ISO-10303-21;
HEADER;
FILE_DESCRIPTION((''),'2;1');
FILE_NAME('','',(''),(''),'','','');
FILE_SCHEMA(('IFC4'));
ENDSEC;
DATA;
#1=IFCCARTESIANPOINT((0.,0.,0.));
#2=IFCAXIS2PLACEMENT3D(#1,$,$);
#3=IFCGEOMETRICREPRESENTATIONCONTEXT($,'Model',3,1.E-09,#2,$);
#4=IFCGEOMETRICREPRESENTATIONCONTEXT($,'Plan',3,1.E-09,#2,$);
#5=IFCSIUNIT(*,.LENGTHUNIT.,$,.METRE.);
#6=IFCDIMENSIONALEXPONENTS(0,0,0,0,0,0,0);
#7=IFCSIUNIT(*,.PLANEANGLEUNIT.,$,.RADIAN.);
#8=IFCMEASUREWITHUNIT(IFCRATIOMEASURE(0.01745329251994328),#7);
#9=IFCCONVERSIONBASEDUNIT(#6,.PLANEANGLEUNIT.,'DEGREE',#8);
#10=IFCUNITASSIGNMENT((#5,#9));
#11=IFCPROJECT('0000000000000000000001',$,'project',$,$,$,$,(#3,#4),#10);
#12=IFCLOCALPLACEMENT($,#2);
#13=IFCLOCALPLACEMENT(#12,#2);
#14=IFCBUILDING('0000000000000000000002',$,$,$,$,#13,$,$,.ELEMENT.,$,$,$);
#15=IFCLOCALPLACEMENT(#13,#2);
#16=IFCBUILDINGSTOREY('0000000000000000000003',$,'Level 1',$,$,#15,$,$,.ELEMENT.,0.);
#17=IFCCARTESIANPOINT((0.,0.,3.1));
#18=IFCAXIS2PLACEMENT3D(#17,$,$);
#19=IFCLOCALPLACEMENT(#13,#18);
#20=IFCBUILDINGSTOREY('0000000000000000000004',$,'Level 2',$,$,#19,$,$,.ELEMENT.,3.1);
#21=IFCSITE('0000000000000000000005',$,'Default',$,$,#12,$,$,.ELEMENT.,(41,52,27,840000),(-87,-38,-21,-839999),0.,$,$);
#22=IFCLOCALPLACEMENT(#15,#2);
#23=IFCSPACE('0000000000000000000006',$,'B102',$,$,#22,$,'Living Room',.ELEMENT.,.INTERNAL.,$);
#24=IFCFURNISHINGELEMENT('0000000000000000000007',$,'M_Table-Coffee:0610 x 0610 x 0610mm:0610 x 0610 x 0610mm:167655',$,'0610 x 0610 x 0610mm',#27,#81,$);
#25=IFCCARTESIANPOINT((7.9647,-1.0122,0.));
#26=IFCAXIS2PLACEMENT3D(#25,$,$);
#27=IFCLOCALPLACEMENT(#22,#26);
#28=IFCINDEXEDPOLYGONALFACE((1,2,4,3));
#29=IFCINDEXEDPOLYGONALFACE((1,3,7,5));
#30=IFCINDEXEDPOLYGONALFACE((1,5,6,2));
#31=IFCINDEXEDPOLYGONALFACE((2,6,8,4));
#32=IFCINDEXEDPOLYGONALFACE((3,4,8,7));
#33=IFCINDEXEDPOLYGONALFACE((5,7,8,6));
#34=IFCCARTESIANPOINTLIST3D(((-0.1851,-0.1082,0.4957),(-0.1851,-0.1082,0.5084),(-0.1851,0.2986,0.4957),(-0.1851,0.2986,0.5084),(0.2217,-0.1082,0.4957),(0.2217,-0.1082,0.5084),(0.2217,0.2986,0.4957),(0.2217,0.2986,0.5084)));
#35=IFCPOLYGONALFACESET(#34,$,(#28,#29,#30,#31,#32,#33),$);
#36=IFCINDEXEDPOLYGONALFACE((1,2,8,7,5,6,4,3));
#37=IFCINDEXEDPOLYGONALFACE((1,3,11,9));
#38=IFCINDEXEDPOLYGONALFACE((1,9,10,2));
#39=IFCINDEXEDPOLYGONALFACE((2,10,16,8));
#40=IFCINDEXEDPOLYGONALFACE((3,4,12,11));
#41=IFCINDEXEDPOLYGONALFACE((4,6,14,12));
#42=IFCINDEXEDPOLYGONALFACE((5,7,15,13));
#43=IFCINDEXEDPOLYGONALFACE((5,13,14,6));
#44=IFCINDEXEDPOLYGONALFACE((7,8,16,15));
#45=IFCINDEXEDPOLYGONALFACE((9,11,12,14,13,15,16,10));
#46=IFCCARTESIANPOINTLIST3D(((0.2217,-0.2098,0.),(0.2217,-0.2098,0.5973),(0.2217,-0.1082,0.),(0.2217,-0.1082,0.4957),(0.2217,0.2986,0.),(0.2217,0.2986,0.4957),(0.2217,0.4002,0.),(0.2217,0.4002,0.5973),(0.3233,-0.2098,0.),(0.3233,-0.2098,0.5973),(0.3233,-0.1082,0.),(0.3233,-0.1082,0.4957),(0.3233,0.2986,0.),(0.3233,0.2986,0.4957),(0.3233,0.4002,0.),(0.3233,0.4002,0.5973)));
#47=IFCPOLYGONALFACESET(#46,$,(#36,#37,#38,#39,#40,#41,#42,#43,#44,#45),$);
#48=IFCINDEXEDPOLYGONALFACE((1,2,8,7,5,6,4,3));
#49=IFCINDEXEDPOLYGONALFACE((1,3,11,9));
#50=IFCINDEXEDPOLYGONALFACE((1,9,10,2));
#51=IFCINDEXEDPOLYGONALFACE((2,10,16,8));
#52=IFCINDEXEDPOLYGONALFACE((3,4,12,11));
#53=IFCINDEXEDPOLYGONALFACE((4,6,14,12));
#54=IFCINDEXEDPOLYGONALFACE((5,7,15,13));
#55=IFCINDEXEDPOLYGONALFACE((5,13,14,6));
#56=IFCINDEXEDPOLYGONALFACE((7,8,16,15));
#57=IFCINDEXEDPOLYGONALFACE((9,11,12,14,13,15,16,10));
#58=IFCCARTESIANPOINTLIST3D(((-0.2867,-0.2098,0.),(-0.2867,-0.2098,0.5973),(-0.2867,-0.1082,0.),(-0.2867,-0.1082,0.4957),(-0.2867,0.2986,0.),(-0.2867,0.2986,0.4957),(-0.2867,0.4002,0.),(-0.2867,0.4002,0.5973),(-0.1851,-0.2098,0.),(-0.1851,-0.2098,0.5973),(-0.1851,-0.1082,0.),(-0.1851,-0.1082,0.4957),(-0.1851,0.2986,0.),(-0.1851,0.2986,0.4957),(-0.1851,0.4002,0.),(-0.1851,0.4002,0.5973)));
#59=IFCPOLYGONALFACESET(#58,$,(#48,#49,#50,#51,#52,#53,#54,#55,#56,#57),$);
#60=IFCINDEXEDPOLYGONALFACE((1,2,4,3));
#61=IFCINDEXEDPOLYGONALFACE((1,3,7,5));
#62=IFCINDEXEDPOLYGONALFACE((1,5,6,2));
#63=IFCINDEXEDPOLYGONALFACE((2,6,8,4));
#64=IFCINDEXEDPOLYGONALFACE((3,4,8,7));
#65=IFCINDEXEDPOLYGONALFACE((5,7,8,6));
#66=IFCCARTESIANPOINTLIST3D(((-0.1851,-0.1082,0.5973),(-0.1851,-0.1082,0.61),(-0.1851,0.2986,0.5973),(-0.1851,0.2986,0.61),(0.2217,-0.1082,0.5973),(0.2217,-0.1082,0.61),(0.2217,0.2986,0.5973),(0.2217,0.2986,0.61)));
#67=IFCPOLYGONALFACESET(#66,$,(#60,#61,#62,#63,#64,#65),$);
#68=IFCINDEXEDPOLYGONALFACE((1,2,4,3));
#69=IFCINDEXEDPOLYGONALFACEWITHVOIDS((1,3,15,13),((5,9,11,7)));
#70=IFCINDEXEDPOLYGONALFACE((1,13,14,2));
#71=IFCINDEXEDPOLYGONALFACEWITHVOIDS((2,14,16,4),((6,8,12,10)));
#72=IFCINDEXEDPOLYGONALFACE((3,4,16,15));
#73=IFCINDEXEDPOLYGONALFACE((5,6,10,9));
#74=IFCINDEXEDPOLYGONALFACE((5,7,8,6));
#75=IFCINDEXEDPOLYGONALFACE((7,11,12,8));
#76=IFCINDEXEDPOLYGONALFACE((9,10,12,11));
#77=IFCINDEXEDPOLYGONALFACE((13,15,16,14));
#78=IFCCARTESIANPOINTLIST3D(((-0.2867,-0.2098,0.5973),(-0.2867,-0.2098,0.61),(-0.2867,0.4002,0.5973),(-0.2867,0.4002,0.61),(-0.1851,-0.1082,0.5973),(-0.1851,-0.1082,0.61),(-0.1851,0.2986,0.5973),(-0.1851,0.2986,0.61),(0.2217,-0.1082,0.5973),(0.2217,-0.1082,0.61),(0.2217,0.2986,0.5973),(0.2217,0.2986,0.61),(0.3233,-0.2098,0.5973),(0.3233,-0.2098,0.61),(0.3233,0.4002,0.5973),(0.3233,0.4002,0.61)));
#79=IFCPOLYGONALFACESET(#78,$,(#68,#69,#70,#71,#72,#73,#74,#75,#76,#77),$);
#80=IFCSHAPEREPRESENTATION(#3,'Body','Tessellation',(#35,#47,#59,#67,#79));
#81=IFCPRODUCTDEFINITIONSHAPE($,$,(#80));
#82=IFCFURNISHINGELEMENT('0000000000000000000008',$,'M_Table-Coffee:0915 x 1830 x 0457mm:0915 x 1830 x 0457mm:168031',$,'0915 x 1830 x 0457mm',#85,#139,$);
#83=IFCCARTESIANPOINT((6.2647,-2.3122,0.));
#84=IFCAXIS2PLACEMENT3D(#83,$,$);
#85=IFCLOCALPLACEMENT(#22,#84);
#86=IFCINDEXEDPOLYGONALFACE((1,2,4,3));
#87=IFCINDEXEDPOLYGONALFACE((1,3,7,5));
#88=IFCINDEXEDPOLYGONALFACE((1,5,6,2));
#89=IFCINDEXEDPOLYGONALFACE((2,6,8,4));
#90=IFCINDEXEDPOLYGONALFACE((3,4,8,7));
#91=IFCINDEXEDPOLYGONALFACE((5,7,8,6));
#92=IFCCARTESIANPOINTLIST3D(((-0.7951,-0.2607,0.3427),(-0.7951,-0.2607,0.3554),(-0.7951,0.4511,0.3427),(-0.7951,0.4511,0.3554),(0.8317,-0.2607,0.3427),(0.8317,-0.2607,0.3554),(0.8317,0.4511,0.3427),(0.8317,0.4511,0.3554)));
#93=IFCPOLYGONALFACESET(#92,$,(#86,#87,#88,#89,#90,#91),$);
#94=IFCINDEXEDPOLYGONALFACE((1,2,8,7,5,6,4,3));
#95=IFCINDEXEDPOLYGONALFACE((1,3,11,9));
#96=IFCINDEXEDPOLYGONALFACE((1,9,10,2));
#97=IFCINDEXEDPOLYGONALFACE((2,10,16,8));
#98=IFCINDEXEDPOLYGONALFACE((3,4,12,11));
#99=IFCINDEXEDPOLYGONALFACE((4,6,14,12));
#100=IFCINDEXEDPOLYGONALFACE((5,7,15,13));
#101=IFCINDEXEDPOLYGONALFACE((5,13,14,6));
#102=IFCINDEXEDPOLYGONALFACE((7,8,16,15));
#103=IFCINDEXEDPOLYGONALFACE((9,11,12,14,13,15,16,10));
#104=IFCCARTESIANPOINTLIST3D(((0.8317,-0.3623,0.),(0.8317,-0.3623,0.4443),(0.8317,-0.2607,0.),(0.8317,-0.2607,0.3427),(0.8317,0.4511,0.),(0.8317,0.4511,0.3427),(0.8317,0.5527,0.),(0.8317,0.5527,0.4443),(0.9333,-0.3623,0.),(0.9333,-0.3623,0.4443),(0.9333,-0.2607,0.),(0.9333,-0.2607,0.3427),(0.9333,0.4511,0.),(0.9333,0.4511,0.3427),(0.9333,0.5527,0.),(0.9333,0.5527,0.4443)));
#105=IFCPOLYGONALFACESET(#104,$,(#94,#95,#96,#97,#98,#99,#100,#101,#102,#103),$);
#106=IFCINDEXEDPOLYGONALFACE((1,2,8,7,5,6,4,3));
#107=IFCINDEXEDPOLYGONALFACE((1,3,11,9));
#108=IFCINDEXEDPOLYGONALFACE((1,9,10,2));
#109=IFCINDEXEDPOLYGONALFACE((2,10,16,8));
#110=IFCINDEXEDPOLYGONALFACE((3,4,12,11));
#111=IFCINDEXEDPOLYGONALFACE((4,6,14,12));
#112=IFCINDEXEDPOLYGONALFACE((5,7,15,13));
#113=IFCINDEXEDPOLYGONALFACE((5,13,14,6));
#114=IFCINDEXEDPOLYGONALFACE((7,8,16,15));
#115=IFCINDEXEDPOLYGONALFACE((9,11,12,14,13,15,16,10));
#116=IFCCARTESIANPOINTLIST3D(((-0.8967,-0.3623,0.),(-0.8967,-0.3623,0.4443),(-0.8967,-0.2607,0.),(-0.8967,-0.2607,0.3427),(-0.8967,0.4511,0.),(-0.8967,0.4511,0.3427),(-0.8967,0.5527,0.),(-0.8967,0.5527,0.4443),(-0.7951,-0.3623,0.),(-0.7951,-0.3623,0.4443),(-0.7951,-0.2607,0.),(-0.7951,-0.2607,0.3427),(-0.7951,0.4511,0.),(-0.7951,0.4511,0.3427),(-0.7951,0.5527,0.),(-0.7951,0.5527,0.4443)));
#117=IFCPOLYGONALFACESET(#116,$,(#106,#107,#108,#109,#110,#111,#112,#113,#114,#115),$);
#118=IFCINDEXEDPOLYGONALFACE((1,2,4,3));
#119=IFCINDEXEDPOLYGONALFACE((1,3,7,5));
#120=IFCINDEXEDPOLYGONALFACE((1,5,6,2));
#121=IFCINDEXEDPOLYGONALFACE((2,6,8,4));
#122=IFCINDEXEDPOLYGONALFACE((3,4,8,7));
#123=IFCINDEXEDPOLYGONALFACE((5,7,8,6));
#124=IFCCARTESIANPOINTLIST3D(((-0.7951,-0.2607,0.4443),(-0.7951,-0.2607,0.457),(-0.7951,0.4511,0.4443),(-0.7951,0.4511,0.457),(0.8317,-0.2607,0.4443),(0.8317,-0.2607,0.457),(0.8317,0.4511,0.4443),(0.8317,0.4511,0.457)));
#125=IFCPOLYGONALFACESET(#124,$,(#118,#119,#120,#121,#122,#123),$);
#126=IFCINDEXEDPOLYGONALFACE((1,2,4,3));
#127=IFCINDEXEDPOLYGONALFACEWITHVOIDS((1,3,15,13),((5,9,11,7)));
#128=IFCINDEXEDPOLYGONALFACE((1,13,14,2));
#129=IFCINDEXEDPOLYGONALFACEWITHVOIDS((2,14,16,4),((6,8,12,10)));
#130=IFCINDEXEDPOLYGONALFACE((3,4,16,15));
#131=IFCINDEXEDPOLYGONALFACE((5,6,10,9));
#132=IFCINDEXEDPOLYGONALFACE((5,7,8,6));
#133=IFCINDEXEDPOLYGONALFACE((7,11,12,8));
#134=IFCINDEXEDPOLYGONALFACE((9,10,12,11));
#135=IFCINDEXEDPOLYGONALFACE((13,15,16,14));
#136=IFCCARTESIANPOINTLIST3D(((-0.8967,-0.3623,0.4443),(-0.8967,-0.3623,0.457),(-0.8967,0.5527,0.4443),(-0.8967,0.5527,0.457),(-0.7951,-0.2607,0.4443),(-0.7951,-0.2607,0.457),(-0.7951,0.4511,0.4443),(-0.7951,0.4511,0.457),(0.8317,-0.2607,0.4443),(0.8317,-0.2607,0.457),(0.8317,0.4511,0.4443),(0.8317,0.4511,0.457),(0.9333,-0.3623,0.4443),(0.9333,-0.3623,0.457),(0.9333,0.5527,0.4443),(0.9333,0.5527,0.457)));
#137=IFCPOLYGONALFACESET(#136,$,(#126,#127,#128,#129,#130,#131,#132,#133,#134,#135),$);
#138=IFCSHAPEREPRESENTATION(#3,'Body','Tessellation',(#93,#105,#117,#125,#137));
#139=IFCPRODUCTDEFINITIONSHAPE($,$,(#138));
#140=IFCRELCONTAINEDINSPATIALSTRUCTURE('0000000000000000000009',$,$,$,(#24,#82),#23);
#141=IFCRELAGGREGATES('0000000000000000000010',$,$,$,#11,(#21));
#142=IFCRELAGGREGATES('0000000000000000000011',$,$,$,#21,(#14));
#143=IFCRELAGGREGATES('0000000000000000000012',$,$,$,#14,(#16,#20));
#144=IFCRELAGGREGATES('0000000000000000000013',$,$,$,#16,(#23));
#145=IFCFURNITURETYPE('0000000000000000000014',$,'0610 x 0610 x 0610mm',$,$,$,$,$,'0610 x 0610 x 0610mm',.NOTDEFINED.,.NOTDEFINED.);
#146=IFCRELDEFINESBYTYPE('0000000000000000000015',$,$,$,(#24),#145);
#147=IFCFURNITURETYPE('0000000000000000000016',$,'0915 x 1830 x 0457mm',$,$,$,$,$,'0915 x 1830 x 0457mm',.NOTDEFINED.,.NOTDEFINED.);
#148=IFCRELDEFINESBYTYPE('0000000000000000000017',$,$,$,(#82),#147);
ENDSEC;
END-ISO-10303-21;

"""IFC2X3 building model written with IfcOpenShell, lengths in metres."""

from ifc_helpers import new_model, entity, si_unit, converted_unit, frame, origin, origin_2d_with_axis, place, context, project, spatial, polyline, rectangle, outline, extrude, source, transform, mapped, type_object, type_shapes, element, save


model = new_model("IFC2X3")

# Units and contexts
model_context = context("Model", 3, precision=1e-09, world=origin())
plan_context = context("Plan", 3, precision=1e-09, world=origin())
ifc_project = project(units=[si_unit("LENGTHUNIT", "METRE"), converted_unit("PLANEANGLEUNIT", "DEGREE", entity("IfcRatioMeasure", 0.01745329251994328), si_unit("PLANEANGLEUNIT", "RADIAN"), dimensions=[0, 0, 0, 0, 0, 0, 0])], contexts=[model_context, plan_context])

# Site, building, storey
site_placement = place(None, origin())
site = spatial("IfcSite", under=ifc_project, at=site_placement, Name="Default", CompositionType="ELEMENT", RefLatitude=(41, 52, 27, 840000), RefLongitude=(-87, -38, -21, -839999), RefElevation=0.0)
building_placement = place(site_placement, origin())
building = spatial("IfcBuilding", under=site, at=building_placement, CompositionType="ELEMENT")
storey_1_placement = place(building_placement, origin())
storey_1 = spatial("IfcBuildingStorey", under=building, at=storey_1_placement, Name="Level 1", CompositionType="ELEMENT", Elevation=0.0)

# Shared definitions
storey_2_placement = place(building_placement, frame((0.0, 0.0, 3.1)))
storey_2 = spatial("IfcBuildingStorey", under=building, at=storey_2_placement, Name="Level 2", CompositionType="ELEMENT", Elevation=3.1)

# Shared definitions
space_1_placement = place(storey_1_placement, origin())
space_1 = spatial("IfcSpace", under=storey_1, at=space_1_placement, Name="B102", LongName="Living Room", CompositionType="ELEMENT", InteriorOrExteriorSpace="INTERNAL")

# Furnishing element
furniture_type_1 = type_object("IfcFurnitureType", Name="0610 x 0610 x 0610mm", ElementType="0610 x 0610 x 0610mm", AssemblyPlace="NOTDEFINED")
shared_shape_1 = source(origin(), model_context, "Body", "SweptSolid", [
    extrude(rectangle(XDim=0.4068, YDim=0.4068, at=origin_2d_with_axis()), frame((0.0183, 0.0952, 0.4957), z_axis=(0.0, 0.0, 1.0), x_axis=(-1.0, 0.0, 0.0)), (0.0, 0.0, 1.0), 0.0127),
    extrude(outline(polyline([(-0.2732, -0.305), (0.324, -0.305), (0.324, 0.305), (-0.2732, 0.305), (-0.2732, 0.2034), (0.2225, 0.2034), (0.2225, -0.2034), (-0.2732, -0.2034), (-0.2732, -0.305)])), frame((0.2217, 0.0952, 0.2732), z_axis=(1.0, 0.0, 0.0), x_axis=(0.0, 0.0, 1.0)), (0.0, 0.0, 1.0), 0.1016),
    extrude(outline(polyline([(-0.305, -0.3241), (0.305, -0.3241), (0.305, 0.2733), (0.2034, 0.2733), (0.2034, -0.2224), (-0.2034, -0.2224), (-0.2034, 0.2733), (-0.305, 0.2733), (-0.305, -0.3241)])), frame((-0.2867, 0.0952, 0.2733), z_axis=(1.0, 0.0, 0.0), x_axis=(0.0, -1.0, 0.0)), (0.0, 0.0, 1.0), 0.1016),
    extrude(rectangle(XDim=0.4068, YDim=0.4068, at=origin_2d_with_axis()), frame((0.0183, 0.0952, 0.5973), z_axis=(0.0, 0.0, 1.0), x_axis=(-1.0, 0.0, 0.0)), (0.0, 0.0, 1.0), 0.0127),
    extrude(outline(polyline([(-0.305, -0.305), (0.305, -0.305), (0.305, 0.305), (-0.305, 0.305), (-0.305, -0.305)]), holes=[polyline([(-0.2034, -0.2034), (-0.2034, 0.2034), (0.2034, 0.2034), (0.2034, -0.2034), (-0.2034, -0.2034)])]), frame((0.0183, 0.0952, 0.5973), z_axis=(0.0, 0.0, 1.0), x_axis=(-1.0, 0.0, 0.0)), (0.0, 0.0, 1.0), 0.0127),
])
type_shapes(furniture_type_1, [shared_shape_1])
for number, where, name in (
    (1, (7.9647, -1.0122, 0.0), "M_Table-Coffee:0610 x 0610 x 0610mm:0610 x 0610 x 0610mm:167655"),
):
    element("IfcFurnishingElement", number, at=place(space_1_placement, frame(where)), inside=space_1, type_object=furniture_type_1, Name=name, ObjectType="0610 x 0610 x 0610mm", context=model_context, shape_type="MappedRepresentation", body=[
        mapped(shared_shape_1, transform((0.0, 0.0, 0.0), scale=1.0)),
    ])

# Furnishing element
furniture_type_2 = type_object("IfcFurnitureType", Name="0915 x 1830 x 0457mm", ElementType="0915 x 1830 x 0457mm", AssemblyPlace="NOTDEFINED")
shared_shape_2 = source(origin(), model_context, "Body", "SweptSolid", [
    extrude(rectangle(XDim=1.6268, YDim=0.7118, at=origin_2d_with_axis()), frame((0.0183, 0.0952, 0.3427), z_axis=(0.0, 0.0, 1.0), x_axis=(-1.0, 0.0, 0.0)), (0.0, 0.0, 1.0), 0.0127),
    extrude(outline(polyline([(-0.1967, -0.4575), (0.2475, -0.4575), (0.2475, 0.4575), (-0.1967, 0.4575), (-0.1967, 0.3559), (0.146, 0.3559), (0.146, -0.3559), (-0.1967, -0.3559), (-0.1967, -0.4575)])), frame((0.8317, 0.0952, 0.1967), z_axis=(1.0, 0.0, 0.0), x_axis=(0.0, 0.0, 1.0)), (0.0, 0.0, 1.0), 0.1016),
    extrude(outline(polyline([(-0.4575, -0.2476), (0.4575, -0.2476), (0.4575, 0.1968), (0.3559, 0.1968), (0.3559, -0.1459), (-0.3559, -0.1459), (-0.3559, 0.1968), (-0.4575, 0.1968), (-0.4575, -0.2476)])), frame((-0.8967, 0.0952, 0.1968), z_axis=(1.0, 0.0, 0.0), x_axis=(0.0, -1.0, 0.0)), (0.0, 0.0, 1.0), 0.1016),
    extrude(rectangle(XDim=1.6268, YDim=0.7118, at=origin_2d_with_axis()), frame((0.0183, 0.0952, 0.4443), z_axis=(0.0, 0.0, 1.0), x_axis=(-1.0, 0.0, 0.0)), (0.0, 0.0, 1.0), 0.0127),
    extrude(outline(polyline([(-0.915, -0.4575), (0.915, -0.4575), (0.915, 0.4575), (-0.915, 0.4575), (-0.915, -0.4575)]), holes=[polyline([(-0.8134, -0.3559), (-0.8134, 0.3559), (0.8134, 0.3559), (0.8134, -0.3559), (-0.8134, -0.3559)])]), frame((0.0183, 0.0952, 0.4443), z_axis=(0.0, 0.0, 1.0), x_axis=(-1.0, 0.0, 0.0)), (0.0, 0.0, 1.0), 0.0127),
])
type_shapes(furniture_type_2, [shared_shape_2])
furnishing_1_placement = place(space_1_placement, frame((6.2647, -2.3122, 0.0)))
element("IfcFurnishingElement", 2, at=furnishing_1_placement, inside=space_1, type_object=furniture_type_2, Name="M_Table-Coffee:0915 x 1830 x 0457mm:0915 x 1830 x 0457mm:168031", ObjectType="0915 x 1830 x 0457mm", context=model_context, shape_type="MappedRepresentation", body=[
    mapped(shared_shape_2, transform((0.0, 0.0, 0.0), scale=1.0)),
])

save(model, "model.ifc")
